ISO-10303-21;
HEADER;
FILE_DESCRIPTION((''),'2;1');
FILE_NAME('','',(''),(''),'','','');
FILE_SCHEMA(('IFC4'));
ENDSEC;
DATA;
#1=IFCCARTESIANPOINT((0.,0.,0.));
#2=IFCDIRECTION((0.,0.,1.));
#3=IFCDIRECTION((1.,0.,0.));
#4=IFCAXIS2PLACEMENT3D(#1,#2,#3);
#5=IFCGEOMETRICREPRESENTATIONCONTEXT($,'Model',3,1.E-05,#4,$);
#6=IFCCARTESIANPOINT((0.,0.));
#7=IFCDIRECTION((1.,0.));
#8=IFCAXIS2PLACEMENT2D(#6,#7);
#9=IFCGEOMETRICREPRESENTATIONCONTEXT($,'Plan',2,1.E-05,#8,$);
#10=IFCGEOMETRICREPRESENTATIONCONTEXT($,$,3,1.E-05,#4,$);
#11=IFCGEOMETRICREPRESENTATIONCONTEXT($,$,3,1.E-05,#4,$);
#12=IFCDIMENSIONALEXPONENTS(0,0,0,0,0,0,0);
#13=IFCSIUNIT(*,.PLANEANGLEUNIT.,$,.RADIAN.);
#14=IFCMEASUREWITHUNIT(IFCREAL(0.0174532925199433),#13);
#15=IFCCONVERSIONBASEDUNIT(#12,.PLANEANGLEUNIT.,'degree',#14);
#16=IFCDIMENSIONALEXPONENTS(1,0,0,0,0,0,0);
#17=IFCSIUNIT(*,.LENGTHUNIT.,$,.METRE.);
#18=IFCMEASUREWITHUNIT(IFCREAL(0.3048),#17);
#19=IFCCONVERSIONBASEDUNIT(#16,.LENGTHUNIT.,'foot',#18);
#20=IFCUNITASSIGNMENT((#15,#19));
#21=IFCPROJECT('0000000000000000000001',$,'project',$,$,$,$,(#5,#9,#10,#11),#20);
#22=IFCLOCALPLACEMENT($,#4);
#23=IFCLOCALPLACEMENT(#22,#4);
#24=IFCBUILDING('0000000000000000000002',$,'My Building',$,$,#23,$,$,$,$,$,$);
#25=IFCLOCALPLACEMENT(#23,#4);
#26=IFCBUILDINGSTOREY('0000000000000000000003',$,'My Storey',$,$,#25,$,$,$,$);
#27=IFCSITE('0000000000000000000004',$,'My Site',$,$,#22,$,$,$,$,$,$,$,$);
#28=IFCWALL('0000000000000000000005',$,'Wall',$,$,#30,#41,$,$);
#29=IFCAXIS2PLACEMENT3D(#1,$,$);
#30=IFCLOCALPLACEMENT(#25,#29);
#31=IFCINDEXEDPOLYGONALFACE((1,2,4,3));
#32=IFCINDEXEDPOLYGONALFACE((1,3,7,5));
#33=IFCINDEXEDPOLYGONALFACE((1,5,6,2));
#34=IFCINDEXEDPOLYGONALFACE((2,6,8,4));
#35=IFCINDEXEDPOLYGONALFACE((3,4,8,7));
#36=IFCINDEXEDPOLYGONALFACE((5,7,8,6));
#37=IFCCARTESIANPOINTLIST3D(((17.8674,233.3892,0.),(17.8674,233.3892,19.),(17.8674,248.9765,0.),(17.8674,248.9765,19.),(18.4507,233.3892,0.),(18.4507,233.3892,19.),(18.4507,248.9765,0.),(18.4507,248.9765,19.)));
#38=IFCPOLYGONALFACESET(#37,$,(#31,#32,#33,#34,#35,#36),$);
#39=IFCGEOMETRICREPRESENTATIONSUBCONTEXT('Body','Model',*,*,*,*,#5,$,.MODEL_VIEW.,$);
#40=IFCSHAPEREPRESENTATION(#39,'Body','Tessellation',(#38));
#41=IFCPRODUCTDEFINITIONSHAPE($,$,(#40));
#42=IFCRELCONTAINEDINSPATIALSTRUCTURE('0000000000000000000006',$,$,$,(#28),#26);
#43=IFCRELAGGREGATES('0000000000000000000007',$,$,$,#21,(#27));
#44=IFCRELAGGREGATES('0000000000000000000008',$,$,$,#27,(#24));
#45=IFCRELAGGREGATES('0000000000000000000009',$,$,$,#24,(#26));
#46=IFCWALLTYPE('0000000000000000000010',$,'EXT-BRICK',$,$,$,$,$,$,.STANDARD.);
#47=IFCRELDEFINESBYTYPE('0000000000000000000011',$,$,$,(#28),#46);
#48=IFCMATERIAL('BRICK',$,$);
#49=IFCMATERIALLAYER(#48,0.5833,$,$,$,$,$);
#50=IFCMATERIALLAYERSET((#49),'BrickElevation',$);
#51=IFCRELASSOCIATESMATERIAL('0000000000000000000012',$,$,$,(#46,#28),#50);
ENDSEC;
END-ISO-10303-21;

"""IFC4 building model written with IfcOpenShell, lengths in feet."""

from ifc_helpers import new_model, entity, si_unit, converted_unit, frame, origin_with_axes, origin_2d_with_axis, place, context, subcontext, project, spatial, indexed_curve, outline, extrude, material, layer, layer_set, layer_usage, type_object, element, save


model = new_model("IFC4")

# Units and contexts
model_context = context("Model", 3, precision=1e-05, world=origin_with_axes())
plan_context = context("Plan", 2, precision=1e-05, world=origin_2d_with_axis())
context_of_model_1 = context(None, 3, precision=1e-05, world=origin_with_axes())
context_of_model_2 = context(None, 3, precision=1e-05, world=origin_with_axes())
body_context = subcontext(model_context, "Body", "Model", "MODEL_VIEW")
ifc_project = project(units=[converted_unit("PLANEANGLEUNIT", "degree", entity("IfcReal", 0.0174532925199433), si_unit("PLANEANGLEUNIT", "RADIAN"), dimensions=[0, 0, 0, 0, 0, 0, 0]), converted_unit("LENGTHUNIT", "foot", entity("IfcReal", 0.3048), si_unit("LENGTHUNIT", "METRE"), dimensions=[1, 0, 0, 0, 0, 0, 0])], contexts=[model_context, plan_context, context_of_model_1, context_of_model_2])

# Site, building, storey
site_placement = place(None, origin_with_axes())
site = spatial("IfcSite", under=ifc_project, at=site_placement, Name="My Site")
building_placement = place(site_placement, origin_with_axes())
building = spatial("IfcBuilding", under=site, at=building_placement, Name="My Building")
storey_placement = place(building_placement, origin_with_axes())
storey = spatial("IfcBuildingStorey", under=building, at=storey_placement, Name="My Storey")

# Wall
ifc_material_1 = material(Name="BRICK")
ifc_layer_1 = layer(ifc_material_1, 0.5833)
ifc_layer_set_1 = layer_set([ifc_layer_1], Name="BrickElevation")
ifc_layer_usage_1 = layer_usage(ifc_layer_set_1, "AXIS2", "POSITIVE", 0.0)
wall_type_1 = type_object("IfcWallType", Name="EXT-BRICK", PredefinedType="STANDARD", material=ifc_layer_set_1)
wall_1_placement = place(storey_placement, frame((18.4507, 233.3892, 0.0), z_axis=(0.0, 0.0, 1.0), x_axis=(0.0, 1.0, 0.0)))
element("IfcWall", 1, at=wall_1_placement, inside=storey, type_object=wall_type_1, material=ifc_layer_usage_1, Name="Wall", context=body_context, shape_type="SweptSolid", body=[
    extrude(outline(indexed_curve([(0.0, 0.0), (0.0, 0.5833), (15.5873, 0.5833), (15.5873, 0.0), (0.0, 0.0)], self_intersect=False)), origin_with_axes(), (0.0, 0.0, 1.0), 19.0),
])

save(model, "model.ifc")
